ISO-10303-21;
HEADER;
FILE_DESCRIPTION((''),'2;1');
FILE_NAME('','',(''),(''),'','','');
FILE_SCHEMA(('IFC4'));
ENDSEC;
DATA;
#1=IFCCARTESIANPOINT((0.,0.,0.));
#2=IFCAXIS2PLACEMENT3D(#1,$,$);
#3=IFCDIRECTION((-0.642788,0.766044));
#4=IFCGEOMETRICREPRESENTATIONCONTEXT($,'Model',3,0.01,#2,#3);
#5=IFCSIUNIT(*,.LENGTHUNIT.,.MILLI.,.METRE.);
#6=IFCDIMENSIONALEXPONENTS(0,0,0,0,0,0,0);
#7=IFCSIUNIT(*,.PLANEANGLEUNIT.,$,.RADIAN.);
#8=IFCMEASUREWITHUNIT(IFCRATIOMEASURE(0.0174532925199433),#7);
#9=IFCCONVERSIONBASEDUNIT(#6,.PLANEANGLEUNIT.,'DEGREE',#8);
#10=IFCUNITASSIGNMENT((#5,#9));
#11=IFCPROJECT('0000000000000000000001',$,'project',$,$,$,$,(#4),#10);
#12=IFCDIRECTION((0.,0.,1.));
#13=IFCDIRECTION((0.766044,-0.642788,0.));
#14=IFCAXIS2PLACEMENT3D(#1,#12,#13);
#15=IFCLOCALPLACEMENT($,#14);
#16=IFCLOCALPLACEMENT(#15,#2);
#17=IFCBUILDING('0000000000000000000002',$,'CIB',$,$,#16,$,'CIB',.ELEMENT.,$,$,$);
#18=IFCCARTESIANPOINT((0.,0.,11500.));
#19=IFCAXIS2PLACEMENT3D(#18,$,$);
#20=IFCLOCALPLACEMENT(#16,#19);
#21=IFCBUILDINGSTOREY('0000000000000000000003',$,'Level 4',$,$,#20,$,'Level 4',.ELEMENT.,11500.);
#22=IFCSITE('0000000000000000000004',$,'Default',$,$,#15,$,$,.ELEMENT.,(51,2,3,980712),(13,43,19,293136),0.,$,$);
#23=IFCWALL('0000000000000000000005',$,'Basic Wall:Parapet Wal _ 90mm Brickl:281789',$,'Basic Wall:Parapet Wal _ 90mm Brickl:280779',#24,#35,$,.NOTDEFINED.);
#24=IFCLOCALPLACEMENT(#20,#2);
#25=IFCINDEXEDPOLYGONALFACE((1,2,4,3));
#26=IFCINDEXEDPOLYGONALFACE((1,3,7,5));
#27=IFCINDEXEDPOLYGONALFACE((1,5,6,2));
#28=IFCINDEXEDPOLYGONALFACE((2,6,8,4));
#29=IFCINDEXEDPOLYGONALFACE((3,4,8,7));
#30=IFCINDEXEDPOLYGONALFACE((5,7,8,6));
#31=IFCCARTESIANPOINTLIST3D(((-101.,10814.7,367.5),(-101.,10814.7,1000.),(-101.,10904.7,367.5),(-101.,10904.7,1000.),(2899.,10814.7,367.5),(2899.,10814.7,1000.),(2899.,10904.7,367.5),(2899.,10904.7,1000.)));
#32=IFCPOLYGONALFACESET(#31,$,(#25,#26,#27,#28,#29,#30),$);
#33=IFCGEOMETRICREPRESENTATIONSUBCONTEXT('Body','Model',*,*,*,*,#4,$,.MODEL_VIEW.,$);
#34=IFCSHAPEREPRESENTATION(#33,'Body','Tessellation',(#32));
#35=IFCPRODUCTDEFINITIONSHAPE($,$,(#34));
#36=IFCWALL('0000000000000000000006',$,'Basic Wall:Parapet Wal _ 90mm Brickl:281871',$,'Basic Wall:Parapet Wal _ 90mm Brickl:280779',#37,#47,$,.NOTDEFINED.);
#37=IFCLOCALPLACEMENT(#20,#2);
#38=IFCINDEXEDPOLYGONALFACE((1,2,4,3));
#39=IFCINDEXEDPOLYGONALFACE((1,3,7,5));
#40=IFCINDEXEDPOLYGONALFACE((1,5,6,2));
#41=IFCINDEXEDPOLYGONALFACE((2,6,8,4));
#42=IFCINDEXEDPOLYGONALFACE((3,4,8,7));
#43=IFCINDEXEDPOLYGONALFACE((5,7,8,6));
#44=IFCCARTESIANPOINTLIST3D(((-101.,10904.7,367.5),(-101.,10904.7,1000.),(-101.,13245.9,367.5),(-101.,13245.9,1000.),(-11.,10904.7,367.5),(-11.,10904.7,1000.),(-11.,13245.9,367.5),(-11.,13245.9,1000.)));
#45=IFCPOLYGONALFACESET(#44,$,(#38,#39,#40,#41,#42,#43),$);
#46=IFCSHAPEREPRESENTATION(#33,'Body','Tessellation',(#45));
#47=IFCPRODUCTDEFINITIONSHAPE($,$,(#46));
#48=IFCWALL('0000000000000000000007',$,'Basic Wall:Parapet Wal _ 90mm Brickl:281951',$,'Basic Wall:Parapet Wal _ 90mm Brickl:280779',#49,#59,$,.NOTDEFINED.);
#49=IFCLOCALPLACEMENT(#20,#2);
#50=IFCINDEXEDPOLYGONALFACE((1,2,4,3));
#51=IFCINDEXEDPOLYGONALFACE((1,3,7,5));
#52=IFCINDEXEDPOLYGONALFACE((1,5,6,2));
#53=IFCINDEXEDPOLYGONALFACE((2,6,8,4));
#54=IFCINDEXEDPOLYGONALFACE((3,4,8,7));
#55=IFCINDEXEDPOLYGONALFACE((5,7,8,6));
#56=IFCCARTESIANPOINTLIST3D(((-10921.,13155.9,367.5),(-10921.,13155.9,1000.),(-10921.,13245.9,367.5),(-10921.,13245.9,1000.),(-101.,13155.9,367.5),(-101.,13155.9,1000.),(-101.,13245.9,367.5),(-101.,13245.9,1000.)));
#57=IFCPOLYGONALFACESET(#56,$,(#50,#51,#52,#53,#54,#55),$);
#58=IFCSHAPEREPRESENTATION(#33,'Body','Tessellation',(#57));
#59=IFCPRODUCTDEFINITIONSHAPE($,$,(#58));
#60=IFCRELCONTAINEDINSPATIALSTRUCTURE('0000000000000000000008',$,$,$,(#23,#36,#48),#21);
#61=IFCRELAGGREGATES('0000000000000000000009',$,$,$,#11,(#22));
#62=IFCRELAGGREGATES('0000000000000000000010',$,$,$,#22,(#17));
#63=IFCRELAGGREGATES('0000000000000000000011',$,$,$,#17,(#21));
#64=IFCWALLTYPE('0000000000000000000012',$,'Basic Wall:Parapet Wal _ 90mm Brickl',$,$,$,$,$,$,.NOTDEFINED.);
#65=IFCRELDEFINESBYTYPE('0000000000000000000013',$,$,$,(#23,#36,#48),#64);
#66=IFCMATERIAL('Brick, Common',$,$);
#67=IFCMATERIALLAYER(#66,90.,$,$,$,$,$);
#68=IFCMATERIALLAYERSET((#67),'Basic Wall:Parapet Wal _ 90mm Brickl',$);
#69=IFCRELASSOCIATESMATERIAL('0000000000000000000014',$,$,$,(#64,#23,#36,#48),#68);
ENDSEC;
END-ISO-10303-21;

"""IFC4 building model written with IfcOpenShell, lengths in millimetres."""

from ifc_helpers import new_model, entity, si_unit, converted_unit, direction, frame, frame_2d, origin, place, context, subcontext, project, spatial, rectangle, extrude, material, layer, layer_set, layer_usage, type_object, element, save


model = new_model("IFC4")

# Units and contexts
model_context = context("Model", 3, precision=0.01, world=origin(), true_north=direction((-0.642788, 0.766044)))
body_context = subcontext(model_context, "Body", "Model", "MODEL_VIEW")
ifc_project = project(units=[si_unit("LENGTHUNIT", "METRE", prefix="MILLI"), converted_unit("PLANEANGLEUNIT", "DEGREE", entity("IfcRatioMeasure", 0.0174532925199433), si_unit("PLANEANGLEUNIT", "RADIAN"), dimensions=[0, 0, 0, 0, 0, 0, 0])], contexts=[model_context])

# Site, building, storey
site_placement = place(None, frame((0.0, 0.0, 0.0), z_axis=(0.0, 0.0, 1.0), x_axis=(0.766044, -0.642788, 0.0)))
site = spatial("IfcSite", under=ifc_project, at=site_placement, Name="Default", CompositionType="ELEMENT", RefLatitude=(51, 2, 3, 980712), RefLongitude=(13, 43, 19, 293136), RefElevation=0.0)
building_placement = place(site_placement, origin())
building = spatial("IfcBuilding", under=site, at=building_placement, Name="CIB", LongName="CIB", CompositionType="ELEMENT")
storey_placement = place(building_placement, frame((0.0, 0.0, 11500.0)))
storey = spatial("IfcBuildingStorey", under=building, at=storey_placement, Name="Level 4", LongName="Level 4", CompositionType="ELEMENT", Elevation=11500.0)

# Shared definitions
ifc_material_1 = material(Name="Brick, Common")

# Walls
ifc_layer_1 = layer(ifc_material_1, 90.0)
ifc_layer_set_1 = layer_set([ifc_layer_1], Name="Basic Wall:Parapet Wal _ 90mm Brickl")
wall_type_1 = type_object("IfcWallType", Name="Basic Wall:Parapet Wal _ 90mm Brickl", PredefinedType="NOTDEFINED", material=ifc_layer_set_1)
ifc_layer_usage_1 = layer_usage(ifc_layer_set_1, "AXIS2", "NEGATIVE", 45.0)
wall_1_placement = place(storey_placement, frame((2899.0, 10859.7, 367.5), z_axis=(0.0, 0.0, 1.0), x_axis=(-1.0, 0.0, 0.0)))
element("IfcWall", 1, at=wall_1_placement, inside=storey, type_object=wall_type_1, material=ifc_layer_usage_1, Name="Basic Wall:Parapet Wal _ 90mm Brickl:281789", ObjectType="Basic Wall:Parapet Wal _ 90mm Brickl:280779", PredefinedType="NOTDEFINED", context=body_context, shape_type="SweptSolid", body=[
    extrude(rectangle(XDim=3000.0, YDim=90.0, at=frame_2d((1500.0, 0.0), x_axis=(-1.0, 0.0))), origin(), (0.0, 0.0, 1.0), 632.5),
])
ifc_layer_usage_2 = layer_usage(ifc_layer_set_1, "AXIS2", "NEGATIVE", 45.0)
wall_2_placement = place(storey_placement, frame((-56.0, 10904.7, 367.5), z_axis=(0.0, 0.0, 1.0), x_axis=(0.0, 1.0, 0.0)))
element("IfcWall", 2, at=wall_2_placement, inside=storey, type_object=wall_type_1, material=ifc_layer_usage_2, Name="Basic Wall:Parapet Wal _ 90mm Brickl:281871", ObjectType="Basic Wall:Parapet Wal _ 90mm Brickl:280779", PredefinedType="NOTDEFINED", context=body_context, shape_type="SweptSolid", body=[
    extrude(rectangle(XDim=2341.3, YDim=90.0, at=frame_2d((1170.6, 0.0), x_axis=(-1.0, 0.0))), origin(), (0.0, 0.0, 1.0), 632.5),
])
ifc_layer_usage_3 = layer_usage(ifc_layer_set_1, "AXIS2", "NEGATIVE", 45.0)
wall_3_placement = place(storey_placement, frame((-101.0, 13200.9, 367.5), z_axis=(0.0, 0.0, 1.0), x_axis=(-1.0, 0.0, 0.0)))
element("IfcWall", 3, at=wall_3_placement, inside=storey, type_object=wall_type_1, material=ifc_layer_usage_3, Name="Basic Wall:Parapet Wal _ 90mm Brickl:281951", ObjectType="Basic Wall:Parapet Wal _ 90mm Brickl:280779", PredefinedType="NOTDEFINED", context=body_context, shape_type="SweptSolid", body=[
    extrude(rectangle(XDim=10820.0, YDim=90.0, at=frame_2d((5410.0, 0.0), x_axis=(-1.0, 0.0))), origin(), (0.0, 0.0, 1.0), 632.5),
])

save(model, "model.ifc")
